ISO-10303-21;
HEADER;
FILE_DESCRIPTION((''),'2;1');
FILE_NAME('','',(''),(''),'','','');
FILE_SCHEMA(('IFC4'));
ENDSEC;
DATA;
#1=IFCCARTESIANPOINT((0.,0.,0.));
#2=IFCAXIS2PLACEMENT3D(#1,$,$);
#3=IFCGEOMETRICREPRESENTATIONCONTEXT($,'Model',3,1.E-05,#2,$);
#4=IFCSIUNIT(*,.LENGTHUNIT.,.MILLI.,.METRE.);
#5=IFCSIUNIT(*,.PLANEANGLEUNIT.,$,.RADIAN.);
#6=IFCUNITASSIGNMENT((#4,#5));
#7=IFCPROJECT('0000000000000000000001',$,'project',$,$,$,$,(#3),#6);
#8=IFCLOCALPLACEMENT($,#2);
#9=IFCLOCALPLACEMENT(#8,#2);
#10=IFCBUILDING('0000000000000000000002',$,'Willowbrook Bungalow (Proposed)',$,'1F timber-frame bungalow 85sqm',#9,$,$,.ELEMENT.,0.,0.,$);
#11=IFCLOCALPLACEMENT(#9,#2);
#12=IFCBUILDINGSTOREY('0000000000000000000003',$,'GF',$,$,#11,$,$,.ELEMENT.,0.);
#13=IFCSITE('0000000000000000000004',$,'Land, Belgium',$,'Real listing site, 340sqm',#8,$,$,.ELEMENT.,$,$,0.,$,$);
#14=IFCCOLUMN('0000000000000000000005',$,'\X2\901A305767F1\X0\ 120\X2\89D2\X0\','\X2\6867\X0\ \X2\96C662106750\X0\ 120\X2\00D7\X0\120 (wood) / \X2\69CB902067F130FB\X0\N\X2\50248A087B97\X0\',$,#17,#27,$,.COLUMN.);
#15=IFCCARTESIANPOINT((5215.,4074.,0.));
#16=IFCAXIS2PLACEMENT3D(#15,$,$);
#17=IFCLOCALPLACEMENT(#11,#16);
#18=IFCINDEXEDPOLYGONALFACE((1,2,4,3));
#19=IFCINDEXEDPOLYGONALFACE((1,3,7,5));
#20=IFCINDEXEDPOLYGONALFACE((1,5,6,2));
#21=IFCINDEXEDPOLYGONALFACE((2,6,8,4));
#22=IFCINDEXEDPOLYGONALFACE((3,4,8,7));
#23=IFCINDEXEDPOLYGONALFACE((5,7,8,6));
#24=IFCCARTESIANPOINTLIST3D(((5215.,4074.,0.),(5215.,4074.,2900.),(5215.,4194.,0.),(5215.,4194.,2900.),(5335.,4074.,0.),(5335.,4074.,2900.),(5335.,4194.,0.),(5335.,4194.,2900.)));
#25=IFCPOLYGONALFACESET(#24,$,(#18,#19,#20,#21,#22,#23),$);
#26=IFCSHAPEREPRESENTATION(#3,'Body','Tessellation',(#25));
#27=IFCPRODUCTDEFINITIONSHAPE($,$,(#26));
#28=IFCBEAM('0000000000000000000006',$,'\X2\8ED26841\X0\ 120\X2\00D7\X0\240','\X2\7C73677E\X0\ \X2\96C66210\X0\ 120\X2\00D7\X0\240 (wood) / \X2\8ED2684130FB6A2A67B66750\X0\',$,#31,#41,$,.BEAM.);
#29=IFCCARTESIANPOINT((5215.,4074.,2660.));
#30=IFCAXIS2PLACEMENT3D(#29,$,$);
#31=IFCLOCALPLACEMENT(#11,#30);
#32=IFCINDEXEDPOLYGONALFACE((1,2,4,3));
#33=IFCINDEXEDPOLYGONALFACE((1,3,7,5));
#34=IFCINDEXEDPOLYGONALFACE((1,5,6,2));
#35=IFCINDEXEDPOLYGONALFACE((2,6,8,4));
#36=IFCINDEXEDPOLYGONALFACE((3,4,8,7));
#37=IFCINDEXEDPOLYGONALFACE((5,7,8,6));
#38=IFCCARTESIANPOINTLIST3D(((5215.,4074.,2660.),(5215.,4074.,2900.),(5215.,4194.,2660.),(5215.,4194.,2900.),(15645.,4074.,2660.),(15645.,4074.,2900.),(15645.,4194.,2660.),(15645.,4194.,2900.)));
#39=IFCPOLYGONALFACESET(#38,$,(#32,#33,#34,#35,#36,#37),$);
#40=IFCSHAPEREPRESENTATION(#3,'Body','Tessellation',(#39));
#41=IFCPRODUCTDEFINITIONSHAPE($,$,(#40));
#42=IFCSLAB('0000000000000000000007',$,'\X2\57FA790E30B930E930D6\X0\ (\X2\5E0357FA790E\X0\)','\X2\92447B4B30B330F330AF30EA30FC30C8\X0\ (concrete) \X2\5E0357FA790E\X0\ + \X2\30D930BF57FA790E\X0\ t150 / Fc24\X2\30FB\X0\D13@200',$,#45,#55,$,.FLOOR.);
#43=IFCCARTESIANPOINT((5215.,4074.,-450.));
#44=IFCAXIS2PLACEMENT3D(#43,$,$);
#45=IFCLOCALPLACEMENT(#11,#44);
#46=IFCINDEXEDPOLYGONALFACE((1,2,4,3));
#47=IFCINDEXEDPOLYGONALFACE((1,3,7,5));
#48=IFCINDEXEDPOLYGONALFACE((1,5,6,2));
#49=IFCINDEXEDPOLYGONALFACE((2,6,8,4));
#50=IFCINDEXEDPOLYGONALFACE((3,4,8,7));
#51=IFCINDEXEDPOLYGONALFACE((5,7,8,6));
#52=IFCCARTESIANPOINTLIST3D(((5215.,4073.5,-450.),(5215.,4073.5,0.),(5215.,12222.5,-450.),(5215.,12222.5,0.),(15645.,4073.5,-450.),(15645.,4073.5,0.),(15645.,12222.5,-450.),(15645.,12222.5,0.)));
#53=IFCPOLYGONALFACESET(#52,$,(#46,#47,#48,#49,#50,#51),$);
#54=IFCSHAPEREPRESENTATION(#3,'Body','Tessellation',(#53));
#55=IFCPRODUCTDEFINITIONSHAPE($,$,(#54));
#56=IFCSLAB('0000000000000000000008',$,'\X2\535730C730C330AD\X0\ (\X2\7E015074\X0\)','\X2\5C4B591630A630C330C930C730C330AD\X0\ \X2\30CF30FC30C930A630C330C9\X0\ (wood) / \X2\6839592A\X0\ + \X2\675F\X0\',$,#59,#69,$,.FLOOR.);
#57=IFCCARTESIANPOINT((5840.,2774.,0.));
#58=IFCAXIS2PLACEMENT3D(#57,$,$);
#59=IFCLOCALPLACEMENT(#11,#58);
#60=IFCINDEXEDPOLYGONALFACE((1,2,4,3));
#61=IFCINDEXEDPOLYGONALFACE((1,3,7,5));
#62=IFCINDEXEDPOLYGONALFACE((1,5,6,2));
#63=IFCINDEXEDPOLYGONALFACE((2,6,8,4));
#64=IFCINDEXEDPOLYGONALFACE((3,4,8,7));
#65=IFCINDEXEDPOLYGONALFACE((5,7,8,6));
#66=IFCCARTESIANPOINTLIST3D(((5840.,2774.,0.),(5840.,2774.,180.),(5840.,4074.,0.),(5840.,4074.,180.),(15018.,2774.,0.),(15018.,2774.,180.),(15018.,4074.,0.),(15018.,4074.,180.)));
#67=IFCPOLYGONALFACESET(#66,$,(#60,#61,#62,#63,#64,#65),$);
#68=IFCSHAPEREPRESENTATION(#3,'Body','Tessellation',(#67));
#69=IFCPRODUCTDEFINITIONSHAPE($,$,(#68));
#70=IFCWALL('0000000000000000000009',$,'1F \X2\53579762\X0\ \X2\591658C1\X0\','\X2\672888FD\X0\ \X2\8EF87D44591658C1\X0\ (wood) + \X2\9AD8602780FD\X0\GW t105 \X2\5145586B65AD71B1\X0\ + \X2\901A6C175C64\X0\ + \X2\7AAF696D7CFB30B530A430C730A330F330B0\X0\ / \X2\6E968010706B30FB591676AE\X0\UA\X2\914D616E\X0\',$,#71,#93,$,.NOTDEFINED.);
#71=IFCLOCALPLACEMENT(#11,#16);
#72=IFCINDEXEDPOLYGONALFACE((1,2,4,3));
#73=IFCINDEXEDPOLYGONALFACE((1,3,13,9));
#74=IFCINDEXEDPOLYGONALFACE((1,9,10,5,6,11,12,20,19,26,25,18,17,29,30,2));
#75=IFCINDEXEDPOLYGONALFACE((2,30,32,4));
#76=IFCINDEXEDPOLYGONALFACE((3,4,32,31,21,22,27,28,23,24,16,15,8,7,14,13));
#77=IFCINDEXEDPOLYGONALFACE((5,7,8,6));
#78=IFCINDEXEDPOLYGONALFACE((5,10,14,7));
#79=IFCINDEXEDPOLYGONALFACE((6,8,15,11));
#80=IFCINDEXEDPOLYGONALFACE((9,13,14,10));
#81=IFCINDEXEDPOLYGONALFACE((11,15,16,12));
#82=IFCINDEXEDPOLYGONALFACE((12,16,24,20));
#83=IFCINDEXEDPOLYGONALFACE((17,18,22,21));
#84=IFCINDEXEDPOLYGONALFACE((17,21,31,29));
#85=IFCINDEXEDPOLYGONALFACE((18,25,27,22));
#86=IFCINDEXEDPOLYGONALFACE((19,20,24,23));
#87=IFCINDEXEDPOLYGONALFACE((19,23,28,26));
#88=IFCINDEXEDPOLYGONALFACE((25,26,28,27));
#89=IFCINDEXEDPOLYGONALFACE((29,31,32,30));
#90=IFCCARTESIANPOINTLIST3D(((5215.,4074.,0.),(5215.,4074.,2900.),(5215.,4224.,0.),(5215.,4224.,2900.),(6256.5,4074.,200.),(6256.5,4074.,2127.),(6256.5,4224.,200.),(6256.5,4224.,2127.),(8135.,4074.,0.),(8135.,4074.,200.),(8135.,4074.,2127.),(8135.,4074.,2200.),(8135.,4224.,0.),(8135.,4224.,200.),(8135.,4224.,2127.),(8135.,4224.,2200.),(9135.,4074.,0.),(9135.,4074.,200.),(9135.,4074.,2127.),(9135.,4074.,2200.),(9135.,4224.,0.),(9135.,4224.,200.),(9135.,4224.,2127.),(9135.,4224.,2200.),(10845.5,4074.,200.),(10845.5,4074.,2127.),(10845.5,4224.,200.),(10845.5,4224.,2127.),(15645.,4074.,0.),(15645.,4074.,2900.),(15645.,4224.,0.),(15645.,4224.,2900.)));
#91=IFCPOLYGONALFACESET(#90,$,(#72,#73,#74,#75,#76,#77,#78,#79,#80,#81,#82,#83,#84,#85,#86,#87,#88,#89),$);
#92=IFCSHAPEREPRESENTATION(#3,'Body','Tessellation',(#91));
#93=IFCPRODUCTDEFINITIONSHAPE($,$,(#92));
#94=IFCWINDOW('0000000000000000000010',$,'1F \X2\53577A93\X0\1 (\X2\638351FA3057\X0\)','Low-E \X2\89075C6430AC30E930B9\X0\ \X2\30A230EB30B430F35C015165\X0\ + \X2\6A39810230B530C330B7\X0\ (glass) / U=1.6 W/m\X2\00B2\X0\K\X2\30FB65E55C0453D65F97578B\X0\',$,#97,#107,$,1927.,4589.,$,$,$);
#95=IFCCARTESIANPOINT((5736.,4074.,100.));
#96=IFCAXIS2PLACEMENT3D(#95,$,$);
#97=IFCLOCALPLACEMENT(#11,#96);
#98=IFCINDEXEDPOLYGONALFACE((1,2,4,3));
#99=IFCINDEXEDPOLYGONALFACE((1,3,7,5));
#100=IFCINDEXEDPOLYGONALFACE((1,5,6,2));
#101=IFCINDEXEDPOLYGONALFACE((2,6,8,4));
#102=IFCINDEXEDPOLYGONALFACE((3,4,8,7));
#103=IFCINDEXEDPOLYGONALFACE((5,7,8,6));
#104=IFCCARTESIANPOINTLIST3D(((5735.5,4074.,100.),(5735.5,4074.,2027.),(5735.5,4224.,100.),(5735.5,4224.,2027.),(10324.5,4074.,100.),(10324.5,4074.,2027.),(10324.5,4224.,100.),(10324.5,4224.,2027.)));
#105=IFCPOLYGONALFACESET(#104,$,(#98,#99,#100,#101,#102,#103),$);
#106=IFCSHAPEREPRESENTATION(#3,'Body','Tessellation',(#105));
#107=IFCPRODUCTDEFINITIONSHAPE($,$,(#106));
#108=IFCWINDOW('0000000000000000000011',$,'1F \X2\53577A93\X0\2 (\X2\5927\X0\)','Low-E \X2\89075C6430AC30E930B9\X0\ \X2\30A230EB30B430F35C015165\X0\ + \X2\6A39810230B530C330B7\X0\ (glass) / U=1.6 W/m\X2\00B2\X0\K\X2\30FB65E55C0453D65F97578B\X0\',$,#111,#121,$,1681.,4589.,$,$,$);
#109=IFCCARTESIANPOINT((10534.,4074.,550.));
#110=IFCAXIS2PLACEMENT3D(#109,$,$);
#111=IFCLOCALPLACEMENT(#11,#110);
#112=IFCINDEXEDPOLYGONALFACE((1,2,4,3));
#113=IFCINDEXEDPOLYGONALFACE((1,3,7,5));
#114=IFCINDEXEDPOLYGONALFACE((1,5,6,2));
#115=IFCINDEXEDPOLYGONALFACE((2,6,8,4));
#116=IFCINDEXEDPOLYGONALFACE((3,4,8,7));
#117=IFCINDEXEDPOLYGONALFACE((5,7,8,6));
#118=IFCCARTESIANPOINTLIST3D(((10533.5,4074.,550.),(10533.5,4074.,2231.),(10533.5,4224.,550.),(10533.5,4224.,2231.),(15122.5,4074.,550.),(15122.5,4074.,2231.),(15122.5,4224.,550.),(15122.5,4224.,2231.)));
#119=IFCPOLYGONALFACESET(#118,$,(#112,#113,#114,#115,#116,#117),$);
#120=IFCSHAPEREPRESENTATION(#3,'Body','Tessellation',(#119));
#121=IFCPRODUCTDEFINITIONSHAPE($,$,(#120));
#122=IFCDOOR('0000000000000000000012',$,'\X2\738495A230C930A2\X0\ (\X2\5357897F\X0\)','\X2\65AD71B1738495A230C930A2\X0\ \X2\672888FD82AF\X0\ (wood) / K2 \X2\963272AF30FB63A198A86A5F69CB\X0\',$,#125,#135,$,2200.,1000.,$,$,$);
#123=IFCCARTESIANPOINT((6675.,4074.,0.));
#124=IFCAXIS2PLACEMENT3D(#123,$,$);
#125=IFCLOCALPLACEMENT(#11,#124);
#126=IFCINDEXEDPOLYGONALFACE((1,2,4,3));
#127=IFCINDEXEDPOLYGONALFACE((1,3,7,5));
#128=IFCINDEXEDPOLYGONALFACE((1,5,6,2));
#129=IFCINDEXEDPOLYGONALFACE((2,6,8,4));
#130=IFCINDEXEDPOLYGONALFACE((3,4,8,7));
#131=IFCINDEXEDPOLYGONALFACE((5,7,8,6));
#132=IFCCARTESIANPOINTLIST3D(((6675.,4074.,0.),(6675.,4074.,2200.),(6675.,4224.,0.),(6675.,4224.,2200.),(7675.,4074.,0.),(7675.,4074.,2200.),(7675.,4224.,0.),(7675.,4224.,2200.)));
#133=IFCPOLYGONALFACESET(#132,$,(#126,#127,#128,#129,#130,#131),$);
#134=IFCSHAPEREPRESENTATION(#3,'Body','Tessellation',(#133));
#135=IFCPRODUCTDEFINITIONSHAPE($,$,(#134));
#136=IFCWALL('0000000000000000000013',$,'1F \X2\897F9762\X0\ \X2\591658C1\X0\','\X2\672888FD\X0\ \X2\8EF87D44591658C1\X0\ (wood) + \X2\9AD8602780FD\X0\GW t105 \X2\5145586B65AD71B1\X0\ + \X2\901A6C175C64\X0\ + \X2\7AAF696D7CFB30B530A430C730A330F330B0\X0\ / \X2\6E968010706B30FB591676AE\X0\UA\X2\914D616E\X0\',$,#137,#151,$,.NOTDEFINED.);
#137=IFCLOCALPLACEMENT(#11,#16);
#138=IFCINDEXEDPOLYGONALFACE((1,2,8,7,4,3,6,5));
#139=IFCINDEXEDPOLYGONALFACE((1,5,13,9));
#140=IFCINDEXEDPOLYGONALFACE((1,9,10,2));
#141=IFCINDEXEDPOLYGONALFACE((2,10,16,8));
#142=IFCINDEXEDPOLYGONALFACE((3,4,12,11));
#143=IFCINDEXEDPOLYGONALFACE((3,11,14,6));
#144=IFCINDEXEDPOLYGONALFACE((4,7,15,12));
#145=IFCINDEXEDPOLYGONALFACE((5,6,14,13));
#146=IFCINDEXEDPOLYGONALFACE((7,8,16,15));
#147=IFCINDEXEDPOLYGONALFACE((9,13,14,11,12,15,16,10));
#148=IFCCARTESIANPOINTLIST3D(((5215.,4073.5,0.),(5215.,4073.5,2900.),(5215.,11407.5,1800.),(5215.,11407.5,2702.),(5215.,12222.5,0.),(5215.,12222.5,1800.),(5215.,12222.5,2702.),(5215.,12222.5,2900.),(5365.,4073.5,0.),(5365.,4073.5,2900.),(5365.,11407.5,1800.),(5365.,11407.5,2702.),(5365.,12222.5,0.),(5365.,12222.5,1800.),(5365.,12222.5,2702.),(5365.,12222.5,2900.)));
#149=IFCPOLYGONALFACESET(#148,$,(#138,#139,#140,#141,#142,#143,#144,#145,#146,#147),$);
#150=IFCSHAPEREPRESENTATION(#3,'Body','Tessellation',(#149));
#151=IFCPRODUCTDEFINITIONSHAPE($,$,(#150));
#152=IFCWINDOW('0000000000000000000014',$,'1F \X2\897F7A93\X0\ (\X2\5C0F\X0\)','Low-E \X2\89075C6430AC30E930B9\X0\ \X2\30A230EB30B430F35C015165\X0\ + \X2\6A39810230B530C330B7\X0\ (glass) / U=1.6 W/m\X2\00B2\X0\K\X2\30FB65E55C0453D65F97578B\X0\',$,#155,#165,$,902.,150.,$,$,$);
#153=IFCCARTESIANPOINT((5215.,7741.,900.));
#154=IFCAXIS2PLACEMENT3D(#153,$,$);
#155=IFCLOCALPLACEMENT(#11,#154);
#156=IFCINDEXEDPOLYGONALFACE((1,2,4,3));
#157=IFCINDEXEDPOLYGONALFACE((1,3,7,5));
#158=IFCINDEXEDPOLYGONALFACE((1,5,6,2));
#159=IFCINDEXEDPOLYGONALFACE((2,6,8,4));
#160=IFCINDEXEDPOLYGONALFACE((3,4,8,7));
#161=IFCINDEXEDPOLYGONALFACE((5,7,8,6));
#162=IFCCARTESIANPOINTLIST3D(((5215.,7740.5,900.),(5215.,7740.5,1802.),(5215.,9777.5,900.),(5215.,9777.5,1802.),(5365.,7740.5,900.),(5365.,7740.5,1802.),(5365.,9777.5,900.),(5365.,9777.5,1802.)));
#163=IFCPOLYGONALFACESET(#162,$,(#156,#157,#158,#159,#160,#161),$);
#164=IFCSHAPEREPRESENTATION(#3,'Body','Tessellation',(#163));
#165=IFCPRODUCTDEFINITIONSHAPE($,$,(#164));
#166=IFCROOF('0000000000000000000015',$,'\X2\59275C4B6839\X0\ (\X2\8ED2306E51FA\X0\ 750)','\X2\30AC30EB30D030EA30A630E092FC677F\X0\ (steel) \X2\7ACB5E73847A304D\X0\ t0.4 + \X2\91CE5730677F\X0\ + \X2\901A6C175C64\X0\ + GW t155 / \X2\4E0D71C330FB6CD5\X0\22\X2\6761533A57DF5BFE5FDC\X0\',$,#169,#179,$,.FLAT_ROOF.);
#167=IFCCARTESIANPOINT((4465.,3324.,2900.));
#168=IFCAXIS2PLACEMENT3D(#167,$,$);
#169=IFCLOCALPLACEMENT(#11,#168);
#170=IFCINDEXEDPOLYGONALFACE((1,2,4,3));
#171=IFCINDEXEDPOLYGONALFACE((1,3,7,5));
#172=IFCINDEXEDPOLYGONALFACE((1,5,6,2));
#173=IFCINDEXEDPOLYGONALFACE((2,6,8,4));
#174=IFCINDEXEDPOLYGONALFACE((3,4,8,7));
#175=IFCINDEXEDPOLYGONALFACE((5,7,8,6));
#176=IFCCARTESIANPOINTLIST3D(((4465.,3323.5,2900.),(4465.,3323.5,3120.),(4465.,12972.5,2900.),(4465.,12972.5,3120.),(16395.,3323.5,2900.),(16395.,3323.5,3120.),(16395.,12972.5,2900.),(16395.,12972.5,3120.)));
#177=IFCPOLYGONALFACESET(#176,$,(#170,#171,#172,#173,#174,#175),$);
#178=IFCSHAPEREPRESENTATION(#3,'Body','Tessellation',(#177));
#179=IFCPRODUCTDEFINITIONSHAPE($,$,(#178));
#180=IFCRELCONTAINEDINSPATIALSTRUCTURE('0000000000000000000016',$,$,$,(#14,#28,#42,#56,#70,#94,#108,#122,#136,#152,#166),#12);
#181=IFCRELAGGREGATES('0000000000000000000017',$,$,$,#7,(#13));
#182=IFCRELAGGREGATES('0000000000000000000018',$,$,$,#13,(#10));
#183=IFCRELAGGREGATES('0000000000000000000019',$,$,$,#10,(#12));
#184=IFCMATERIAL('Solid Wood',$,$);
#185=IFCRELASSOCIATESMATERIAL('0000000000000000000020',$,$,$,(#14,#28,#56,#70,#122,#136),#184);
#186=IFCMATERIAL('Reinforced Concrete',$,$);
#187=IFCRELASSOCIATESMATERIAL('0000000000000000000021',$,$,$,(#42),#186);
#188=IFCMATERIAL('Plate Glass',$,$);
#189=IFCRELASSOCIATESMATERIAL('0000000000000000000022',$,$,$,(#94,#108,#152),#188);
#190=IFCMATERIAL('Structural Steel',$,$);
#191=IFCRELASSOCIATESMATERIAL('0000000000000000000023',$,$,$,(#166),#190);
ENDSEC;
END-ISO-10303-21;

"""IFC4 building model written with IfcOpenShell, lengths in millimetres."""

from ifc_helpers import new_model, si_unit, frame, frame_2d, origin, place, context, project, spatial, rectangle, extrude, material, element, fill, save


model = new_model("IFC4")

# Units and contexts
model_context = context("Model", 3, precision=1e-05, world=origin())
ifc_project = project(units=[si_unit("LENGTHUNIT", "METRE", prefix="MILLI"), si_unit("PLANEANGLEUNIT", "RADIAN")], contexts=[model_context])

# Site, building, storey
site_placement = place(None, origin())
site = spatial("IfcSite", under=ifc_project, at=site_placement, Name="Land, Belgium", ObjectType="Real listing site, 340sqm", CompositionType="ELEMENT", RefElevation=0.0)
building_placement = place(site_placement, origin())
building = spatial("IfcBuilding", under=site, at=building_placement, Name="Willowbrook Bungalow (Proposed)", ObjectType="1F timber-frame bungalow 85sqm", CompositionType="ELEMENT", ElevationOfRefHeight=0.0, ElevationOfTerrain=0.0)
storey_placement = place(building_placement, origin())
storey = spatial("IfcBuildingStorey", under=building, at=storey_placement, Name="GF", CompositionType="ELEMENT", Elevation=0.0)

# Column
ifc_material_1 = material(Name="Solid Wood")
column_1_placement = place(storey_placement, frame((5215.0, 4074.0, 0.0)))
element("IfcColumn", 1, at=column_1_placement, inside=storey, material=ifc_material_1, Name="通し柱 120角", Description="桧 集成材 120×120 (wood) / 構造柱・N値計算", PredefinedType="COLUMN", context=model_context, shape_type="SweptSolid", body=[
    extrude(rectangle(XDim=120.0, YDim=120.0, at=frame_2d((60.0, 60.0))), frame((5215.0, 4074.0, 0.0)), (0.0, 0.0, 1.0), 2900.0),
])

# Beam
beam_1_placement = place(storey_placement, frame((5215.0, 4074.0, 2660.0)))
element("IfcBeam", 2, at=beam_1_placement, inside=storey, material=ifc_material_1, Name="軒桁 120×240", Description="米松 集成 120×240 (wood) / 軒桁・横架材", PredefinedType="BEAM", context=model_context, shape_type="SweptSolid", body=[
    extrude(rectangle(XDim=10430.0, YDim=120.0, at=frame_2d((5215.0, 60.0))), frame((5215.0, 4074.0, 2660.0)), (0.0, 0.0, 1.0), 240.0),
])

# Slabs
ifc_material_2 = material(Name="Reinforced Concrete")
slab_1_placement = place(storey_placement, frame((5215.0, 4074.0, -450.0)))
element("IfcSlab", 3, at=slab_1_placement, inside=storey, material=ifc_material_2, Name="基礎スラブ (布基礎)", Description="鉄筋コンクリート (concrete) 布基礎 + ベタ基礎 t150 / Fc24・D13@200", PredefinedType="FLOOR", context=model_context, shape_type="SweptSolid", body=[
    extrude(rectangle(XDim=10430.0, YDim=8149.0, at=frame_2d((5215.0, 4074.0))), frame((5215.0, 4074.0, -450.0)), (0.0, 0.0, 1.0), 450.0),
])
slab_2_placement = place(storey_placement, frame((5840.0, 2774.0, 0.0)))
element("IfcSlab", 4, at=slab_2_placement, inside=storey, material=ifc_material_1, Name="南デッキ (縁側)", Description="屋外ウッドデッキ ハードウッド (wood) / 根太 + 束", PredefinedType="FLOOR", context=model_context, shape_type="SweptSolid", body=[
    extrude(rectangle(XDim=9178.0, YDim=1300.0, at=frame_2d((4589.0, 650.0))), frame((5840.0, 2774.0, 0.0)), (0.0, 0.0, 1.0), 180.0),
])

# Wall, openings, windows, door
wall_1_placement = place(storey_placement, frame((5215.0, 4074.0, 0.0)))
wall_1 = element("IfcWall", 5, at=wall_1_placement, inside=storey, material=ifc_material_1, Name="1F 南面 外壁", Description="木製 軸組外壁 (wood) + 高性能GW t105 充填断熱 + 通気層 + 窯業系サイディング / 準耐火・外皮UA配慮", PredefinedType="NOTDEFINED", context=model_context, shape_type="SweptSolid", body=[
    extrude(rectangle(XDim=10430.0, YDim=150.0, at=frame_2d((5215.0, 75.0))), frame((5215.0, 4074.0, 0.0)), (0.0, 0.0, 1.0), 2900.0),
])
opening_1_placement = place(storey_placement, frame((5736.0, 4074.0, 100.0)))
opening_1 = element("IfcOpeningElement", 6, at=opening_1_placement, cuts=wall_1, PredefinedType="NOTDEFINED", context=model_context, shape_type="SweptSolid", body=[
    extrude(rectangle(XDim=4589.0, YDim=150.0, at=frame_2d((2294.0, 75.0))), frame((5736.0, 4074.0, 100.0)), (0.0, 0.0, 1.0), 1927.0),
])
opening_2_placement = place(storey_placement, frame((10534.0, 4074.0, 550.0)))
opening_2 = element("IfcOpeningElement", 7, at=opening_2_placement, cuts=wall_1, PredefinedType="NOTDEFINED", context=model_context, shape_type="SweptSolid", body=[
    extrude(rectangle(XDim=4589.0, YDim=150.0, at=frame_2d((2294.0, 75.0))), frame((10534.0, 4074.0, 550.0)), (0.0, 0.0, 1.0), 1681.0),
])
opening_3_placement = place(storey_placement, frame((6675.0, 4074.0, 0.0)))
opening_3 = element("IfcOpeningElement", 8, at=opening_3_placement, cuts=wall_1, PredefinedType="NOTDEFINED", context=model_context, shape_type="SweptSolid", body=[
    extrude(rectangle(XDim=1000.0, YDim=150.0, at=frame_2d((500.0, 75.0))), frame((6675.0, 4074.0, 0.0)), (0.0, 0.0, 1.0), 2200.0),
])
ifc_material_3 = material(Name="Plate Glass")
window_1_placement = place(storey_placement, frame((5736.0, 4074.0, 100.0)))
window_1 = element("IfcWindow", 9, at=window_1_placement, inside=storey, material=ifc_material_3, Name="1F 南窓1 (掃出し)", Description="Low-E 複層ガラス アルゴン封入 + 樹脂サッシ (glass) / U=1.6 W/m²K・日射取得型", OverallHeight=1927.0, OverallWidth=4589.0, context=model_context, shape_type="SweptSolid", body=[
    extrude(rectangle(XDim=4589.0, YDim=150.0, at=frame_2d((2294.0, 75.0))), frame((5736.0, 4074.0, 100.0)), (0.0, 0.0, 1.0), 1927.0),
])
fill(opening_1, window_1)
window_2_placement = place(storey_placement, frame((10534.0, 4074.0, 550.0)))
window_2 = element("IfcWindow", 10, at=window_2_placement, inside=storey, material=ifc_material_3, Name="1F 南窓2 (大)", Description="Low-E 複層ガラス アルゴン封入 + 樹脂サッシ (glass) / U=1.6 W/m²K・日射取得型", OverallHeight=1681.0, OverallWidth=4589.0, context=model_context, shape_type="SweptSolid", body=[
    extrude(rectangle(XDim=4589.0, YDim=150.0, at=frame_2d((2294.0, 75.0))), frame((10534.0, 4074.0, 550.0)), (0.0, 0.0, 1.0), 1681.0),
])
fill(opening_2, window_2)
door_placement = place(storey_placement, frame((6675.0, 4074.0, 0.0)))
door = element("IfcDoor", 11, at=door_placement, inside=storey, material=ifc_material_1, Name="玄関ドア (南西)", Description="断熱玄関ドア 木製芯 (wood) / K2 防犯・採風機構", OverallHeight=2200.0, OverallWidth=1000.0, context=model_context, shape_type="SweptSolid", body=[
    extrude(rectangle(XDim=1000.0, YDim=150.0, at=frame_2d((500.0, 75.0))), frame((6675.0, 4074.0, 0.0)), (0.0, 0.0, 1.0), 2200.0),
])
fill(opening_3, door)

# Wall, opening, window
wall_2_placement = place(storey_placement, frame((5215.0, 4074.0, 0.0)))
wall_2 = element("IfcWall", 12, at=wall_2_placement, inside=storey, material=ifc_material_1, Name="1F 西面 外壁", Description="木製 軸組外壁 (wood) + 高性能GW t105 充填断熱 + 通気層 + 窯業系サイディング / 準耐火・外皮UA配慮", PredefinedType="NOTDEFINED", context=model_context, shape_type="SweptSolid", body=[
    extrude(rectangle(XDim=150.0, YDim=8149.0, at=frame_2d((75.0, 4074.0))), frame((5215.0, 4074.0, 0.0)), (0.0, 0.0, 1.0), 2900.0),
])
opening_4_placement = place(storey_placement, frame((5215.0, 7741.0, 900.0)))
opening_4 = element("IfcOpeningElement", 13, at=opening_4_placement, cuts=wall_2, PredefinedType="NOTDEFINED", context=model_context, shape_type="SweptSolid", body=[
    extrude(rectangle(XDim=150.0, YDim=2037.0, at=frame_2d((75.0, 1018.0))), frame((5215.0, 7741.0, 900.0)), (0.0, 0.0, 1.0), 902.0),
])
window_3_placement = place(storey_placement, frame((5215.0, 7741.0, 900.0)))
window_3 = element("IfcWindow", 14, at=window_3_placement, inside=storey, material=ifc_material_3, Name="1F 西窓 (小)", Description="Low-E 複層ガラス アルゴン封入 + 樹脂サッシ (glass) / U=1.6 W/m²K・日射取得型", OverallHeight=902.0, OverallWidth=150.0, context=model_context, shape_type="SweptSolid", body=[
    extrude(rectangle(XDim=150.0, YDim=2037.0, at=frame_2d((75.0, 1018.0))), frame((5215.0, 7741.0, 900.0)), (0.0, 0.0, 1.0), 902.0),
])
fill(opening_4, window_3)

# Roof
ifc_material_4 = material(Name="Structural Steel")
roof_placement = place(storey_placement, frame((4465.0, 3324.0, 2900.0)))
element("IfcRoof", 15, at=roof_placement, inside=storey, material=ifc_material_4, Name="大屋根 (軒の出 750)", Description="ガルバリウム鋼板 (steel) 立平葺き t0.4 + 野地板 + 通気層 + GW t155 / 不燃・法22条区域対応", PredefinedType="FLAT_ROOF", context=model_context, shape_type="SweptSolid", body=[
    extrude(rectangle(XDim=11930.0, YDim=9649.0, at=frame_2d((5965.0, 4824.0))), frame((4465.0, 3324.0, 2900.0)), (0.0, 0.0, 1.0), 220.0),
])

save(model, "model.ifc")
